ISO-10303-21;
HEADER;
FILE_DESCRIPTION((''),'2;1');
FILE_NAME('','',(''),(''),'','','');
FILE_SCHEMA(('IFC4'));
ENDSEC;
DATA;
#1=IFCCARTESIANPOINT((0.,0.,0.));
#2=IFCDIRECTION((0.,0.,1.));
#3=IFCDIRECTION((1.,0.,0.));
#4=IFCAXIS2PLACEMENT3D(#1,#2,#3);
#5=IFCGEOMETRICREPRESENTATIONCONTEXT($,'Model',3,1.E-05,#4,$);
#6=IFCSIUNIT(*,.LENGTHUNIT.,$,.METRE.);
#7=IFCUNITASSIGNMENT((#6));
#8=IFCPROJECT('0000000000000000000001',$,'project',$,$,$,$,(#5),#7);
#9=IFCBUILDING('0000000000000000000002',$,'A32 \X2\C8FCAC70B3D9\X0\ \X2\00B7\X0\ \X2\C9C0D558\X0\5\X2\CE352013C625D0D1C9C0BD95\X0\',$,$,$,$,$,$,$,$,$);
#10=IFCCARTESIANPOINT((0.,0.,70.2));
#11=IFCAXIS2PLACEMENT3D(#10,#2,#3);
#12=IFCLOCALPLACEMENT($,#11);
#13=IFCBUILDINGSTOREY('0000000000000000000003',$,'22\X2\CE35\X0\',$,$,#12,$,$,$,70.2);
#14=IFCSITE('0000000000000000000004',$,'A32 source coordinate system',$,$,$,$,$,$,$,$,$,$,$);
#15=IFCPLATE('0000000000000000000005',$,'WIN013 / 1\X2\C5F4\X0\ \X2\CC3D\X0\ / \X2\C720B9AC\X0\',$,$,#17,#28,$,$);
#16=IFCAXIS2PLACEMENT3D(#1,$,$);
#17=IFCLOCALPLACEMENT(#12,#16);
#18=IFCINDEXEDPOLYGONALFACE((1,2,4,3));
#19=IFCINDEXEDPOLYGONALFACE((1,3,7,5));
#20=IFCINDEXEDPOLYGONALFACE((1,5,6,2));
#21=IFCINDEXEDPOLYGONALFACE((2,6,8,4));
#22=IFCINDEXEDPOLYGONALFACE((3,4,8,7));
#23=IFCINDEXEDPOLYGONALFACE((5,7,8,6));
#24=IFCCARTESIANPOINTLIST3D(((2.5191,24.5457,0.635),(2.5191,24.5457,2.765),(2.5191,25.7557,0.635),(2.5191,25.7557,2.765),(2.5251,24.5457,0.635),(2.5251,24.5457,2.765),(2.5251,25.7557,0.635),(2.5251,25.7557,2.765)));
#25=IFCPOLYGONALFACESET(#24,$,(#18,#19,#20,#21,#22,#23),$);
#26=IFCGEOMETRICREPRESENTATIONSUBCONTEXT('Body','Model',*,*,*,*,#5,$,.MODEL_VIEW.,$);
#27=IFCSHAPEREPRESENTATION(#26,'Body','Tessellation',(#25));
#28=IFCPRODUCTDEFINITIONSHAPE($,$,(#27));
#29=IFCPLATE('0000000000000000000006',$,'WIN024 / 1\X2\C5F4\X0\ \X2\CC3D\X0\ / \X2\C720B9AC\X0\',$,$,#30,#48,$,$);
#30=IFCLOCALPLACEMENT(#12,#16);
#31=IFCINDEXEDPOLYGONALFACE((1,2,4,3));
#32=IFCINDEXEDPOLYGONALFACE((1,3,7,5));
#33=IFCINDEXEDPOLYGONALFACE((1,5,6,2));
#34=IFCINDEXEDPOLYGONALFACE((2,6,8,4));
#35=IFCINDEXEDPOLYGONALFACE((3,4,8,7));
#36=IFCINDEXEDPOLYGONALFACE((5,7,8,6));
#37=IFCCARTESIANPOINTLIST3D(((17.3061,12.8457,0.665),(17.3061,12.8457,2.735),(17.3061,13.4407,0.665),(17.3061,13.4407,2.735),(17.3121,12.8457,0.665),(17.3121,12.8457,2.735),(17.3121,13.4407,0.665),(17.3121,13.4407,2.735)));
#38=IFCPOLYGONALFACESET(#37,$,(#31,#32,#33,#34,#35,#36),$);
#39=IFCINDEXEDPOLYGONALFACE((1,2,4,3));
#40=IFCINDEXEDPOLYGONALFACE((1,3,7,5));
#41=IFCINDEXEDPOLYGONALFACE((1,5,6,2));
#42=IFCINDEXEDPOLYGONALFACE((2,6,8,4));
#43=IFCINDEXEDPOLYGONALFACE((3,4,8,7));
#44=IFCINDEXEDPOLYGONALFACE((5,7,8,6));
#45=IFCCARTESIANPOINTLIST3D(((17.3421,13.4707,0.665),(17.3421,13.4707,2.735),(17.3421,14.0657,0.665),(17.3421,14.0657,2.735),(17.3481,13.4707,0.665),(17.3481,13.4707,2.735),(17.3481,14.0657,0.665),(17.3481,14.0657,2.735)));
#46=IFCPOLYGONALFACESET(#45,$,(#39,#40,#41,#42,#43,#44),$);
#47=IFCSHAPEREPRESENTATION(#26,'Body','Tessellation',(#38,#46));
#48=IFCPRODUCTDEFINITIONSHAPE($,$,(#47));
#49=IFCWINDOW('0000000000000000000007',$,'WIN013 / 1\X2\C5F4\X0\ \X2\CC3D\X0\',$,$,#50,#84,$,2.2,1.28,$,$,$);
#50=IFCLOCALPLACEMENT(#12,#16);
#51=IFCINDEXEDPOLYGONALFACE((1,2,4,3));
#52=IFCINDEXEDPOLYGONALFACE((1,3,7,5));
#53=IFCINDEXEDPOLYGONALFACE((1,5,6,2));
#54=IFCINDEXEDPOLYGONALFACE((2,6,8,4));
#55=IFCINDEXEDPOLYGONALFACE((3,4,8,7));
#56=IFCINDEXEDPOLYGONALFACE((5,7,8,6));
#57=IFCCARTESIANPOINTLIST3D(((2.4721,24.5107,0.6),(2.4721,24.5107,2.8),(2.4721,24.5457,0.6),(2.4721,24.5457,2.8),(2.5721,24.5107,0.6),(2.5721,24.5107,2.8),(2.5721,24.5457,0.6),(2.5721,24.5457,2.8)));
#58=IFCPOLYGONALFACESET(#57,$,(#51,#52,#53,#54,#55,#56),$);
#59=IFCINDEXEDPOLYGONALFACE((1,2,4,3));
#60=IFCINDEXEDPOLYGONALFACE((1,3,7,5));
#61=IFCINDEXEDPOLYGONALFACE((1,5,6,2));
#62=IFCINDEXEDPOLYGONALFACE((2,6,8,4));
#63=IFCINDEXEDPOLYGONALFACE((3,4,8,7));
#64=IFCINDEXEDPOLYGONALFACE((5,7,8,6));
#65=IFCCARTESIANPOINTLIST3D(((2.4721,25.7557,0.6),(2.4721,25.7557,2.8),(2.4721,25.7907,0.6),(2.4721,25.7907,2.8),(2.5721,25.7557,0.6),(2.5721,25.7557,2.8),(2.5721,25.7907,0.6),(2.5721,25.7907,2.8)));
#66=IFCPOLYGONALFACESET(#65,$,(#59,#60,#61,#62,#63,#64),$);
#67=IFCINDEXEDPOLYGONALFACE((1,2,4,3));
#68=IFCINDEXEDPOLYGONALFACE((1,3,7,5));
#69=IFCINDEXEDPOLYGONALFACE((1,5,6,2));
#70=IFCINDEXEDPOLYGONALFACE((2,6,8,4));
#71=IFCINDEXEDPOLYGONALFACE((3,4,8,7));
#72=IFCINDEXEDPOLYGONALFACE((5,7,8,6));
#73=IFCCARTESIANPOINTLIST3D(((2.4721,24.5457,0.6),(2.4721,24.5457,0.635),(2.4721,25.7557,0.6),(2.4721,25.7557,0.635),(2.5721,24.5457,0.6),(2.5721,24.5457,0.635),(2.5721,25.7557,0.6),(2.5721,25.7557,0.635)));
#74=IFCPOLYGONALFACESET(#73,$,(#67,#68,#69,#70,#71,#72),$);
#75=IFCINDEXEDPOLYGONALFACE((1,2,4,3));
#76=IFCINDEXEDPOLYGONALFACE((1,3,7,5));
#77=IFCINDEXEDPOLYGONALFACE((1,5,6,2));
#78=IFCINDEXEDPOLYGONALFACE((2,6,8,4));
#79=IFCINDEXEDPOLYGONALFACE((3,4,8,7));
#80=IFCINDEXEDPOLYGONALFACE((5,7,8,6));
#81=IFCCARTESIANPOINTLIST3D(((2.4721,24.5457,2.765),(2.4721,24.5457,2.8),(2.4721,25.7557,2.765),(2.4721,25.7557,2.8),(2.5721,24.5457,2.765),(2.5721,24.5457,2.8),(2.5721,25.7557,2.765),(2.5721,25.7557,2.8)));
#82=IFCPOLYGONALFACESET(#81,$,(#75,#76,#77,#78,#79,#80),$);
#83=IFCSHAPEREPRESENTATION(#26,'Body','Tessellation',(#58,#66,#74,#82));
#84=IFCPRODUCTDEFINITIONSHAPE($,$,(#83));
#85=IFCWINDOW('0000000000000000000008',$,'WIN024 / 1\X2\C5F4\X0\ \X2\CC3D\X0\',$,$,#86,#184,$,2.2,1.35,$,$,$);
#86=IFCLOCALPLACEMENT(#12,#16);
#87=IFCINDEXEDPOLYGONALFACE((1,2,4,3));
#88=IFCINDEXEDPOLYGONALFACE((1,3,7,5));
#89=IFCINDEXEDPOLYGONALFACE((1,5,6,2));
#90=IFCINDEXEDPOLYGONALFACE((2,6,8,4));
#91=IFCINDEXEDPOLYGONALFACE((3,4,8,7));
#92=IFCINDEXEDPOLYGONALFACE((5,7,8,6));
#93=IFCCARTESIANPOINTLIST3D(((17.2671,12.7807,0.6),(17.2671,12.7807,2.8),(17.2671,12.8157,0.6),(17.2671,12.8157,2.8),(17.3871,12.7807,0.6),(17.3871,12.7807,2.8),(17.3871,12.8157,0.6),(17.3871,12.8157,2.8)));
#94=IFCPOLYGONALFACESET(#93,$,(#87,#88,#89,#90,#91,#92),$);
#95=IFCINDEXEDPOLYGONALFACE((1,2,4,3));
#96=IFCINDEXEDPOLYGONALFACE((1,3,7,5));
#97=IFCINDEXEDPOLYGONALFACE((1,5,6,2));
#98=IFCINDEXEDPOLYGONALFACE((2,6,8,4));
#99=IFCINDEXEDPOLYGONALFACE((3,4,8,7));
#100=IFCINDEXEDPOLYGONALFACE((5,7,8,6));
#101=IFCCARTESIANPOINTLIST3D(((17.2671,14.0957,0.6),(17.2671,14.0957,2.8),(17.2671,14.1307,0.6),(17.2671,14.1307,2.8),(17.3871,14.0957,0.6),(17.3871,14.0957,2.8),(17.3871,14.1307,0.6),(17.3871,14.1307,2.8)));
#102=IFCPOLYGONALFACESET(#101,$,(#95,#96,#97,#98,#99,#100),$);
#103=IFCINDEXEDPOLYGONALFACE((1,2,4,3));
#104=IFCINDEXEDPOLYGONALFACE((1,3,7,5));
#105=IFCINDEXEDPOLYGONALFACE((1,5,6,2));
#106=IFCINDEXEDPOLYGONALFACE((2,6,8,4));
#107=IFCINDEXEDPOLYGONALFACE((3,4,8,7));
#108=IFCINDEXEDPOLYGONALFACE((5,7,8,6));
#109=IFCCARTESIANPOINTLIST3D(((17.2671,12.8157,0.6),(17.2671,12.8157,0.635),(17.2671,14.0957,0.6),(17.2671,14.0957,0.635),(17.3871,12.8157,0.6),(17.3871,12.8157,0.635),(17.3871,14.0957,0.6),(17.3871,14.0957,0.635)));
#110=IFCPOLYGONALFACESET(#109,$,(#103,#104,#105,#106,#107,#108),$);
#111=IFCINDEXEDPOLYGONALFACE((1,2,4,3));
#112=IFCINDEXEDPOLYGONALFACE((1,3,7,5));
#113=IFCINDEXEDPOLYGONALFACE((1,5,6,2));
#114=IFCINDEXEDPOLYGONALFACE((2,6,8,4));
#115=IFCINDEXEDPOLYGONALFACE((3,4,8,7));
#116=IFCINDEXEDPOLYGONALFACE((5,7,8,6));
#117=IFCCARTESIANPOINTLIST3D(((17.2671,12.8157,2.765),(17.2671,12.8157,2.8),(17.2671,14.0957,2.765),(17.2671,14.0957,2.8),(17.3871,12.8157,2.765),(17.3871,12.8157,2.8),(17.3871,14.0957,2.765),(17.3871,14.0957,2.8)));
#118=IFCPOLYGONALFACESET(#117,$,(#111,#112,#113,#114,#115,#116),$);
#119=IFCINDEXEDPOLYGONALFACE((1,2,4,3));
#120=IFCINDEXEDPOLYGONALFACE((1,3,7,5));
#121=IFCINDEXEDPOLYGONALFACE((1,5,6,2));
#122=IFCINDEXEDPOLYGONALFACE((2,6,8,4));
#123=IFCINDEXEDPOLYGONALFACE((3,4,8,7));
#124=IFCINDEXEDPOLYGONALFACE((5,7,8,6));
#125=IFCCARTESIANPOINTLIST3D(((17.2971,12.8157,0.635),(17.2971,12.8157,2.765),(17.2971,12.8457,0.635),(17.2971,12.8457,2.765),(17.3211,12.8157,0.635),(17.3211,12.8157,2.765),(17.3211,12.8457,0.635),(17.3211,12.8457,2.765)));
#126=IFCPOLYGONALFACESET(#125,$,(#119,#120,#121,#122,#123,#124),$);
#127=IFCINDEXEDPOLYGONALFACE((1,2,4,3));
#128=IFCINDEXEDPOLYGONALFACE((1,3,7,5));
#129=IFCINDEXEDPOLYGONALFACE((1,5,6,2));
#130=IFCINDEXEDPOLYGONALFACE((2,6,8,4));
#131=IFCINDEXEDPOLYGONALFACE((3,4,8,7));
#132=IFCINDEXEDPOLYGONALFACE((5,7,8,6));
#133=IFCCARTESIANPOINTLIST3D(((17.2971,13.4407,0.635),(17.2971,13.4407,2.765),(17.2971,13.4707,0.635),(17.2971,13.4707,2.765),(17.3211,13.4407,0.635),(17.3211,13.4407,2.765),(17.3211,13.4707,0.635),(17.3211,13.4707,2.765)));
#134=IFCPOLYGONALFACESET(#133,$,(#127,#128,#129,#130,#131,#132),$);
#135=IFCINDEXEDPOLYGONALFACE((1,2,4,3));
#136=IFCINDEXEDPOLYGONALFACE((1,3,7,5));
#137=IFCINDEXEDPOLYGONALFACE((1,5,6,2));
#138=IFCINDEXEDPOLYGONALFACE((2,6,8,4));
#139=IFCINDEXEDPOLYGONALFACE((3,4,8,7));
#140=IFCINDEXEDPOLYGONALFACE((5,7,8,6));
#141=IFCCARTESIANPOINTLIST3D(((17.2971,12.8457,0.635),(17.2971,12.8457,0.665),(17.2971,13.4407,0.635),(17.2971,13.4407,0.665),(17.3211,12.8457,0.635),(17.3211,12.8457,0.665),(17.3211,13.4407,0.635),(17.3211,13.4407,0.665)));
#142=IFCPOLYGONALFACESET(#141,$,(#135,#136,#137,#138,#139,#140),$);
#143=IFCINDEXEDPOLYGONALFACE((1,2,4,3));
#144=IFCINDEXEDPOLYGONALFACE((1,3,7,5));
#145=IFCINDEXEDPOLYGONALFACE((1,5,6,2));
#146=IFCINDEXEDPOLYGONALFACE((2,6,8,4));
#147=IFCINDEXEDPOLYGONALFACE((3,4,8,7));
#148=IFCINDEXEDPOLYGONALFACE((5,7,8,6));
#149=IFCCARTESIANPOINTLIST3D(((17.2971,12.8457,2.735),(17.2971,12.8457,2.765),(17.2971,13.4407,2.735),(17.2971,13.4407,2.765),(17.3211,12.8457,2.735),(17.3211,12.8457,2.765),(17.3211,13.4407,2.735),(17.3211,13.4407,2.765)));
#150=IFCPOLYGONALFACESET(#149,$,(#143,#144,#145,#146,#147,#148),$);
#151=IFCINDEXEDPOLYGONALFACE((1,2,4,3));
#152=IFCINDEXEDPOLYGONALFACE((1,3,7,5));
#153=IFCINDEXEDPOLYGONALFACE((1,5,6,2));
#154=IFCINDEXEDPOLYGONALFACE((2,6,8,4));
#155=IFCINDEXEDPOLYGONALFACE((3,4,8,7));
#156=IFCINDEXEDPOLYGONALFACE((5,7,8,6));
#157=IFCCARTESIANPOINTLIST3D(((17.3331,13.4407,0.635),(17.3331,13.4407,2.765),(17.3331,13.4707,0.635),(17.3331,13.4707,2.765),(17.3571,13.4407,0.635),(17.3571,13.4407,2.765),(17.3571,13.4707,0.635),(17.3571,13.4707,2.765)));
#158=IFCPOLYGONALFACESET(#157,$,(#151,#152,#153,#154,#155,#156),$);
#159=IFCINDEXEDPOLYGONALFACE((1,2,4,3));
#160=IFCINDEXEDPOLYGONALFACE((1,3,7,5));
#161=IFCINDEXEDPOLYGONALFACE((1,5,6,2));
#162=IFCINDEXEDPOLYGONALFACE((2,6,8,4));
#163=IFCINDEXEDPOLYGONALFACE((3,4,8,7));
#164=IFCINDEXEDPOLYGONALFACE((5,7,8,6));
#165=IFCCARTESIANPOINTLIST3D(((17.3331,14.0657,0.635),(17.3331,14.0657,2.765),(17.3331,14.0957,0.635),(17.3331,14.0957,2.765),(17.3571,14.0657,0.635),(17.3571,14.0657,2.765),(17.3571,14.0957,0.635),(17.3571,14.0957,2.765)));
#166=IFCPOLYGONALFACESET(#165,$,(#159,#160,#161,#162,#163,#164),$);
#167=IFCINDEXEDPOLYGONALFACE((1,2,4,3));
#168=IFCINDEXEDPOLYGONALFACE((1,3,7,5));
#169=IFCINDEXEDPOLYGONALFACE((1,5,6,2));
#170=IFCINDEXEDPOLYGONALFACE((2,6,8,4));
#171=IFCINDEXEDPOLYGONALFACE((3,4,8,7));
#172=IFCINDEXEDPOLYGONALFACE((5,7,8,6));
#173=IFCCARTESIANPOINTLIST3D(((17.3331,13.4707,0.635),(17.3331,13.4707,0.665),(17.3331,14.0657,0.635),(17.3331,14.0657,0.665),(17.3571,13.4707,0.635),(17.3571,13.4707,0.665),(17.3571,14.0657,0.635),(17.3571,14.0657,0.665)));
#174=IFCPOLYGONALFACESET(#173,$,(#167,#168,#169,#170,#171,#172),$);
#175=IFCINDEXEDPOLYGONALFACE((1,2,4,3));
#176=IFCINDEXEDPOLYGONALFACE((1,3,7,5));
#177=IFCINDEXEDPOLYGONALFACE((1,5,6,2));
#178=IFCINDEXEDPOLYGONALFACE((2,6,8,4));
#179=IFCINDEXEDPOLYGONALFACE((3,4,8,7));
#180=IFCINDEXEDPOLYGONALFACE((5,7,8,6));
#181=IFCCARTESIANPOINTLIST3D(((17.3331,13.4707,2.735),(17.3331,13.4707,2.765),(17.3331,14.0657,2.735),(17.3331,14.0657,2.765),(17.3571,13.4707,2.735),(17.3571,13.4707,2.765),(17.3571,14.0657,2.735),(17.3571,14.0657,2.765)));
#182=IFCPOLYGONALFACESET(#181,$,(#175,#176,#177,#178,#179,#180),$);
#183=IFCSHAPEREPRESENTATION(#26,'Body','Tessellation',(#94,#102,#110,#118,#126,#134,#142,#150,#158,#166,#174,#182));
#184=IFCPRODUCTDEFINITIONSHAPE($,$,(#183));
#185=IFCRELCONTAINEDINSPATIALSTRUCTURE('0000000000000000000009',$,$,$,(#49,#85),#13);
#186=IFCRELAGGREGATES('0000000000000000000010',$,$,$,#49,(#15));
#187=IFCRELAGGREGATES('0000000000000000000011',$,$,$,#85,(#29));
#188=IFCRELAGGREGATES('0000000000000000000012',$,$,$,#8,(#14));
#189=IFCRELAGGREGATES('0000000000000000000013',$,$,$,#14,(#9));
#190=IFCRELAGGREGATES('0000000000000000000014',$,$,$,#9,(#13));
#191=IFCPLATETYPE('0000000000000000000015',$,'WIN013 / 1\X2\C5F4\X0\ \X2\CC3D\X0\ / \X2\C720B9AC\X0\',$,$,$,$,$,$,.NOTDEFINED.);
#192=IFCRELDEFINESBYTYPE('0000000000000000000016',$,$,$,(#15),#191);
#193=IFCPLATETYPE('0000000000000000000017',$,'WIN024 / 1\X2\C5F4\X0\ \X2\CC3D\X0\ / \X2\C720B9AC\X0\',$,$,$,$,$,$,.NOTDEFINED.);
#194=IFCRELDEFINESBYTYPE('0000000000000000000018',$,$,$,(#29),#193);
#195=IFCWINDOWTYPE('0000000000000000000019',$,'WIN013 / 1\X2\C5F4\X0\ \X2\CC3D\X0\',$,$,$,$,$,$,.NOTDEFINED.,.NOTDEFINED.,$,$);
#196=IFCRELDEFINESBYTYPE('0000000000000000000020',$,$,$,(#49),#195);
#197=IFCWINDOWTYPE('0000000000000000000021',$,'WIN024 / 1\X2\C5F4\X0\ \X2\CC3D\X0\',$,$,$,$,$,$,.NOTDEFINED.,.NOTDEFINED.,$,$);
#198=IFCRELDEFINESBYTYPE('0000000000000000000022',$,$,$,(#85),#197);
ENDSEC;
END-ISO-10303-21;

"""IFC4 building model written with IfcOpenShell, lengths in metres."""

from ifc_helpers import new_model, si_unit, frame, origin, origin_with_axes, place, context, subcontext, project, spatial, polyline, outline, extrude, source, transform, mapped, type_object, type_shapes, element, aggregate, save


model = new_model("IFC4")

# Units and contexts
model_context = context("Model", 3, precision=1e-05, world=origin_with_axes())
body_context = subcontext(model_context, "Body", "Model", "MODEL_VIEW")
ifc_project = project(units=[si_unit("LENGTHUNIT", "METRE")], contexts=[model_context])

# Plates
plate_type_1 = type_object("IfcPlateType", Name="WIN013 / 1열 창 / 유리", PredefinedType="NOTDEFINED")
shared_shape_1 = source(origin(), body_context, "Body", "SweptSolid", [
    extrude(outline(polyline([(2.5191, 24.5457), (2.5191, 25.7557), (2.5251, 25.7557), (2.5251, 24.5457), (2.5191, 24.5457)])), frame((0.0, 0.0, 0.635)), (0.0, 0.0, 1.0), 2.13),
])
type_shapes(plate_type_1, [shared_shape_1])
storey_placement = place(None, frame((0.0, 0.0, 70.2), z_axis=(0.0, 0.0, 1.0), x_axis=(1.0, 0.0, 0.0)))
window_1_placement = place(storey_placement, origin_with_axes())
plate_1_placement = place(window_1_placement, origin_with_axes())
plate_1 = element("IfcPlate", 1, at=plate_1_placement, type_object=plate_type_1, Name="WIN013 / 1열 창 / 유리", context=body_context, shape_type="MappedRepresentation", body=[
    mapped(shared_shape_1, transform((0.0, 0.0, 0.0), scale=1.0)),
])
plate_type_2 = type_object("IfcPlateType", Name="WIN024 / 1열 창 / 유리", PredefinedType="NOTDEFINED")
shared_shape_2 = source(origin(), body_context, "Body", "SweptSolid", [
    extrude(outline(polyline([(17.3061, 12.8457), (17.3061, 13.4407), (17.3121, 13.4407), (17.3121, 12.8457), (17.3061, 12.8457)])), frame((0.0, 0.0, 0.665)), (0.0, 0.0, 1.0), 2.07),
    extrude(outline(polyline([(17.3421, 13.4707), (17.3421, 14.0657), (17.3481, 14.0657), (17.3481, 13.4707), (17.3421, 13.4707)])), frame((0.0, 0.0, 0.665)), (0.0, 0.0, 1.0), 2.07),
])
type_shapes(plate_type_2, [shared_shape_2])
window_2_placement = place(storey_placement, origin_with_axes())
plate_2_placement = place(window_2_placement, origin_with_axes())
plate_2 = element("IfcPlate", 2, at=plate_2_placement, type_object=plate_type_2, Name="WIN024 / 1열 창 / 유리", context=body_context, shape_type="MappedRepresentation", body=[
    mapped(shared_shape_2, transform((0.0, 0.0, 0.0), scale=1.0)),
])

# Site, building, storey
site = spatial("IfcSite", under=ifc_project, Name="A32 source coordinate system")
building = spatial("IfcBuilding", under=site, Name="A32 주거동 · 지하5층–옥탑지붕")
storey = spatial("IfcBuildingStorey", under=building, at=storey_placement, Name="22층", Elevation=70.2)

# Windows
window_type_1 = type_object("IfcWindowType", Name="WIN013 / 1열 창", PartitioningType="NOTDEFINED", PredefinedType="NOTDEFINED")
shared_shape_3 = source(origin(), body_context, "Body", "SweptSolid", [
    extrude(outline(polyline([(2.4721, 24.5107), (2.4721, 24.5457), (2.5721, 24.5457), (2.5721, 24.5107), (2.4721, 24.5107)])), frame((0.0, 0.0, 0.6)), (0.0, 0.0, 1.0), 2.2),
    extrude(outline(polyline([(2.4721, 25.7557), (2.4721, 25.7907), (2.5721, 25.7907), (2.5721, 25.7557), (2.4721, 25.7557)])), frame((0.0, 0.0, 0.6)), (0.0, 0.0, 1.0), 2.2),
    extrude(outline(polyline([(2.4721, 24.5457), (2.4721, 25.7557), (2.5721, 25.7557), (2.5721, 24.5457), (2.4721, 24.5457)])), frame((0.0, 0.0, 0.6)), (0.0, 0.0, 1.0), 0.035),
    extrude(outline(polyline([(2.4721, 24.5457), (2.4721, 25.7557), (2.5721, 25.7557), (2.5721, 24.5457), (2.4721, 24.5457)])), frame((0.0, 0.0, 2.765)), (0.0, 0.0, 1.0), 0.035),
])
type_shapes(window_type_1, [shared_shape_3])
window_1 = element("IfcWindow", 3, at=window_1_placement, inside=storey, type_object=window_type_1, Name="WIN013 / 1열 창", OverallHeight=2.2, OverallWidth=1.28, context=body_context, shape_type="MappedRepresentation", body=[
    mapped(shared_shape_3, transform((0.0, 0.0, 0.0), scale=1.0)),
])
aggregate(window_1, [plate_1])
window_type_2 = type_object("IfcWindowType", Name="WIN024 / 1열 창", PartitioningType="NOTDEFINED", PredefinedType="NOTDEFINED")
shared_shape_4 = source(origin(), body_context, "Body", "SweptSolid", [
    extrude(outline(polyline([(17.2671, 12.7807), (17.2671, 12.8157), (17.3871, 12.8157), (17.3871, 12.7807), (17.2671, 12.7807)])), frame((0.0, 0.0, 0.6)), (0.0, 0.0, 1.0), 2.2),
    extrude(outline(polyline([(17.2671, 14.0957), (17.2671, 14.1307), (17.3871, 14.1307), (17.3871, 14.0957), (17.2671, 14.0957)])), frame((0.0, 0.0, 0.6)), (0.0, 0.0, 1.0), 2.2),
    extrude(outline(polyline([(17.2671, 12.8157), (17.2671, 14.0957), (17.3871, 14.0957), (17.3871, 12.8157), (17.2671, 12.8157)])), frame((0.0, 0.0, 0.6)), (0.0, 0.0, 1.0), 0.035),
    extrude(outline(polyline([(17.2671, 12.8157), (17.2671, 14.0957), (17.3871, 14.0957), (17.3871, 12.8157), (17.2671, 12.8157)])), frame((0.0, 0.0, 2.765)), (0.0, 0.0, 1.0), 0.035),
    extrude(outline(polyline([(17.2971, 12.8157), (17.2971, 12.8457), (17.3211, 12.8457), (17.3211, 12.8157), (17.2971, 12.8157)])), frame((0.0, 0.0, 0.635)), (0.0, 0.0, 1.0), 2.13),
    extrude(outline(polyline([(17.2971, 13.4407), (17.2971, 13.4707), (17.3211, 13.4707), (17.3211, 13.4407), (17.2971, 13.4407)])), frame((0.0, 0.0, 0.635)), (0.0, 0.0, 1.0), 2.13),
    extrude(outline(polyline([(17.2971, 12.8457), (17.2971, 13.4407), (17.3211, 13.4407), (17.3211, 12.8457), (17.2971, 12.8457)])), frame((0.0, 0.0, 0.635)), (0.0, 0.0, 1.0), 0.03),
    extrude(outline(polyline([(17.2971, 12.8457), (17.2971, 13.4407), (17.3211, 13.4407), (17.3211, 12.8457), (17.2971, 12.8457)])), frame((0.0, 0.0, 2.735)), (0.0, 0.0, 1.0), 0.03),
    extrude(outline(polyline([(17.3331, 13.4407), (17.3331, 13.4707), (17.3571, 13.4707), (17.3571, 13.4407), (17.3331, 13.4407)])), frame((0.0, 0.0, 0.635)), (0.0, 0.0, 1.0), 2.13),
    extrude(outline(polyline([(17.3331, 14.0657), (17.3331, 14.0957), (17.3571, 14.0957), (17.3571, 14.0657), (17.3331, 14.0657)])), frame((0.0, 0.0, 0.635)), (0.0, 0.0, 1.0), 2.13),
    extrude(outline(polyline([(17.3331, 13.4707), (17.3331, 14.0657), (17.3571, 14.0657), (17.3571, 13.4707), (17.3331, 13.4707)])), frame((0.0, 0.0, 0.635)), (0.0, 0.0, 1.0), 0.03),
    extrude(outline(polyline([(17.3331, 13.4707), (17.3331, 14.0657), (17.3571, 14.0657), (17.3571, 13.4707), (17.3331, 13.4707)])), frame((0.0, 0.0, 2.735)), (0.0, 0.0, 1.0), 0.03),
])
type_shapes(window_type_2, [shared_shape_4])
window_2 = element("IfcWindow", 4, at=window_2_placement, inside=storey, type_object=window_type_2, Name="WIN024 / 1열 창", OverallHeight=2.2, OverallWidth=1.35, context=body_context, shape_type="MappedRepresentation", body=[
    mapped(shared_shape_4, transform((0.0, 0.0, 0.0), scale=1.0)),
])
aggregate(window_2, [plate_2])

save(model, "model.ifc")
